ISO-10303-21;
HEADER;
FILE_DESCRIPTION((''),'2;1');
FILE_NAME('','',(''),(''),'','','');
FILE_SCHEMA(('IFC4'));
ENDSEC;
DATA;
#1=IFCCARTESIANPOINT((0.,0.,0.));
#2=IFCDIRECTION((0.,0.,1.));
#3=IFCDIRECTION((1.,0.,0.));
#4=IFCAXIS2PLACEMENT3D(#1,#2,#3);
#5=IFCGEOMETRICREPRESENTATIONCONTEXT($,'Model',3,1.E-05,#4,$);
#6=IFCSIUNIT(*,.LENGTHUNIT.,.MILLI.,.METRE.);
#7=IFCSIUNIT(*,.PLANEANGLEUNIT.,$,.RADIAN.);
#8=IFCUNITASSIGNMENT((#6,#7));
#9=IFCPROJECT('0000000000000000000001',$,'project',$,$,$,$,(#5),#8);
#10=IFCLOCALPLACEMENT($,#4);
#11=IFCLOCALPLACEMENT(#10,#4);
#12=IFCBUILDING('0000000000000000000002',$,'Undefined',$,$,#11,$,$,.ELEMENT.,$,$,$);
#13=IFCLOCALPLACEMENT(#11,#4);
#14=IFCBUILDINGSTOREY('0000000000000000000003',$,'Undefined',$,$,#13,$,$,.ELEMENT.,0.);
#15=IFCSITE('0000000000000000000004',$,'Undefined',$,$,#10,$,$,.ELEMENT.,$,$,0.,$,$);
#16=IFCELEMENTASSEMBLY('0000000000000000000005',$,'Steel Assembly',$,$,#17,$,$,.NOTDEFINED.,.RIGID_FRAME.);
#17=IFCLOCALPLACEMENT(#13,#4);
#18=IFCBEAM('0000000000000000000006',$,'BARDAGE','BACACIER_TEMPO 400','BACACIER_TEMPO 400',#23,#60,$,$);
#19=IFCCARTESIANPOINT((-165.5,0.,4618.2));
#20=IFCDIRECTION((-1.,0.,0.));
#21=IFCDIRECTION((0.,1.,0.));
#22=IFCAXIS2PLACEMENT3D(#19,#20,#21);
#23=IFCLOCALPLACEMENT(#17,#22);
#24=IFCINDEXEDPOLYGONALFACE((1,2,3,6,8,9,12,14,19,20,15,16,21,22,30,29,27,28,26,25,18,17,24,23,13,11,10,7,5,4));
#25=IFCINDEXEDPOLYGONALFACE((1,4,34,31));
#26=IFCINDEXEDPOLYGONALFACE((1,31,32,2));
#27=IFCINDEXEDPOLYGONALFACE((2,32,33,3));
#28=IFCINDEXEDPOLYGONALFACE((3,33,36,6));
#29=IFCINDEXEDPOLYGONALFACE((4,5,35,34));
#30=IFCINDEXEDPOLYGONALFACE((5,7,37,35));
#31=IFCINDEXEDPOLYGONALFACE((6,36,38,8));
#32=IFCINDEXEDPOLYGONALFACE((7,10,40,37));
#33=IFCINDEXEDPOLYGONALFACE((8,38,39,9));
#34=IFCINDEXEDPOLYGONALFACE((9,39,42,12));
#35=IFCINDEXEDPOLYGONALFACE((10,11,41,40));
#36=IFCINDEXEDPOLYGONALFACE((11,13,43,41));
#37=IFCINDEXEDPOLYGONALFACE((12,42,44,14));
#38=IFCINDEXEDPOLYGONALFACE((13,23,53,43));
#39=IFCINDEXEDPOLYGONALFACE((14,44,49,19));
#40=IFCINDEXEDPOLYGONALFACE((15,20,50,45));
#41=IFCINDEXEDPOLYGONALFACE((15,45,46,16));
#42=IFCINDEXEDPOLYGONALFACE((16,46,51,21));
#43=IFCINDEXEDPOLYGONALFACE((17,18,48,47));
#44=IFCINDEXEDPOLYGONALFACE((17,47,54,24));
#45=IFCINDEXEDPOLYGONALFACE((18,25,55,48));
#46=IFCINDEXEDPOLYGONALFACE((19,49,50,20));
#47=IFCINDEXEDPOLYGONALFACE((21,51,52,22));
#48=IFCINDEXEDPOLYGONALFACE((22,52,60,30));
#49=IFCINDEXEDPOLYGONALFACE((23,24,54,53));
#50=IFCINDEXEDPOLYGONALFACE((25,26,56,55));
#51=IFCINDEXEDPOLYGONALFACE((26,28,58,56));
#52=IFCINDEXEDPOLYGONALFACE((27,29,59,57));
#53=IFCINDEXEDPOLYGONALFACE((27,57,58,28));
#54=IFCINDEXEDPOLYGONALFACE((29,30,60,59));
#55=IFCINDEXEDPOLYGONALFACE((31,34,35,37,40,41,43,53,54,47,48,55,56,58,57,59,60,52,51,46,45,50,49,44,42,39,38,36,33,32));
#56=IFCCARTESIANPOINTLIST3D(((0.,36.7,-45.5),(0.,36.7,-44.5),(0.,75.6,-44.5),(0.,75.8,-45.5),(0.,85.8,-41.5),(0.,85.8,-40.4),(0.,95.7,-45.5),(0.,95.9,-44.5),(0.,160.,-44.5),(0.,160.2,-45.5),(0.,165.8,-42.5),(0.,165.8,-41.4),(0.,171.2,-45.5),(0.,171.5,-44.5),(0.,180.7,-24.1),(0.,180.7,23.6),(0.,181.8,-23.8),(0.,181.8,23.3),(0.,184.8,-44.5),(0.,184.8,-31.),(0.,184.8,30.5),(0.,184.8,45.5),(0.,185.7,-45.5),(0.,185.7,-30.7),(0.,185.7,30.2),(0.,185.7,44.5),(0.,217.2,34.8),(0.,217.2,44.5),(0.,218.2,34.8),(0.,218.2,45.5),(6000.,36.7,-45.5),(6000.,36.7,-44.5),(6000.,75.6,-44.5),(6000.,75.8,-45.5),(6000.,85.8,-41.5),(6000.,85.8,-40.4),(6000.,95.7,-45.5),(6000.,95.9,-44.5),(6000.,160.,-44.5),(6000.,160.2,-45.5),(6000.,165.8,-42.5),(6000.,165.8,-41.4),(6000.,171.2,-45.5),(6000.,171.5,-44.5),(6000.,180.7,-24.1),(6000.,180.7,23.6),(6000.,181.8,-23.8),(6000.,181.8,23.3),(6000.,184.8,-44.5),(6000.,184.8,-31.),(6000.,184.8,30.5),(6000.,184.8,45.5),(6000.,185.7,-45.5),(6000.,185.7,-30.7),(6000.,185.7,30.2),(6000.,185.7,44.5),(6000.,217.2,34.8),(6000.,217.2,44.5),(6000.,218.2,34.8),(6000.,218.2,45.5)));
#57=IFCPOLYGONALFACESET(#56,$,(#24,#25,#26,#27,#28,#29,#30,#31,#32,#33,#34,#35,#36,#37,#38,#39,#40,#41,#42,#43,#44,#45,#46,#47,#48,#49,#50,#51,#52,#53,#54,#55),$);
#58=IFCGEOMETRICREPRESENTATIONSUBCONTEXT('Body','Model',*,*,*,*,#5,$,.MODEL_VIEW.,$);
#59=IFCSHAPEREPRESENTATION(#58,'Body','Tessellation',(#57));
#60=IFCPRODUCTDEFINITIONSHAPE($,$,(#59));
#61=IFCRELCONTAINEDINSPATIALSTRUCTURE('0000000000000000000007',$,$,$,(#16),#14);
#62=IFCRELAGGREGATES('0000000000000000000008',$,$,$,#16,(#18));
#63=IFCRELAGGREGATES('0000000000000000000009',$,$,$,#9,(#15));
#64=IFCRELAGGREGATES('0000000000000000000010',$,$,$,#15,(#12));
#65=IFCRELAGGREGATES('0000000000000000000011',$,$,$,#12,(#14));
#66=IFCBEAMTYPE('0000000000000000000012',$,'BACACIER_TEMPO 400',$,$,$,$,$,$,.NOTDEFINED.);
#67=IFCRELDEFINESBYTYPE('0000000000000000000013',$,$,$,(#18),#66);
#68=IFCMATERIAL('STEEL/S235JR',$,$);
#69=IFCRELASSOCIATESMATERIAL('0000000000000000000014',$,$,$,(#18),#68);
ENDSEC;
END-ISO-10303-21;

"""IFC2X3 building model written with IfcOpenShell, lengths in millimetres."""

from ifc_helpers import new_model, si_unit, frame, origin_with_axes, place, context, subcontext, project, spatial, polyline, outline, extrude, clip, halfspace, material, type_object, element, aggregate, save


model = new_model("IFC2X3")

# Units and contexts
model_context = context("Model", 3, precision=1e-05, world=origin_with_axes())
body_context = subcontext(model_context, "Body", "Model", "MODEL_VIEW")
ifc_project = project(units=[si_unit("LENGTHUNIT", "METRE", prefix="MILLI"), si_unit("PLANEANGLEUNIT", "RADIAN")], contexts=[model_context])

# Site, building, storey
site_placement = place(None, origin_with_axes())
site = spatial("IfcSite", under=ifc_project, at=site_placement, Name="Undefined", CompositionType="ELEMENT", RefElevation=0.0)
building_placement = place(site_placement, origin_with_axes())
building = spatial("IfcBuilding", under=site, at=building_placement, Name="Undefined", CompositionType="ELEMENT")
storey_placement = place(building_placement, origin_with_axes())
storey = spatial("IfcBuildingStorey", under=building, at=storey_placement, Name="Undefined", CompositionType="ELEMENT", Elevation=0.0)

# Element assembly, beam
ifc_material_1 = material(Name="STEEL/S235JR")
assembly_1_placement = place(storey_placement, origin_with_axes())
assembly_1 = element("IfcElementAssembly", 1, at=assembly_1_placement, inside=storey, Name="Steel Assembly", AssemblyPlace="NOTDEFINED", PredefinedType="RIGID_FRAME")
beam_type_1 = type_object("IfcBeamType", Name="BACACIER_TEMPO 400", PredefinedType="NOTDEFINED")
beam_1_placement = place(assembly_1_placement, frame((-165.5, 0.0, 4618.2), z_axis=(-1.0, 0.0, 0.0), x_axis=(0.0, 1.0, 0.0)))
beam_1 = element("IfcBeam", 2, at=beam_1_placement, type_object=beam_type_1, material=ifc_material_1, Name="BARDAGE", Description="BACACIER_TEMPO 400", ObjectType="BACACIER_TEMPO 400", context=body_context, shape_type="Clipping", body=[
    clip(extrude(outline(polyline([(218.2, -25.0), (214.2, -31.9), (214.2, -45.5), (199.8, -45.5), (194.2, -42.5), (188.8, -45.5), (124.2, -45.5), (114.2, -41.5), (104.2, -45.5), (24.2, -45.5), (14.2, -41.5), (4.2, -45.5), (-75.8, -45.5), (-85.8, -41.5), (-95.8, -45.5), (-160.2, -45.5), (-165.8, -42.5), (-171.2, -45.5), (-185.8, -45.5), (-185.8, -30.7), (-181.8, -23.8), (-181.8, 23.3), (-185.8, 30.2), (-185.8, 44.5), (-217.2, 44.5), (-217.2, 34.8), (-218.2, 34.8), (-218.2, 45.5), (-184.8, 45.5), (-184.8, 30.5), (-180.8, 23.6), (-180.8, -24.1), (-184.8, -31.0), (-184.8, -44.5), (-171.5, -44.5), (-165.8, -41.4), (-160.0, -44.5), (-95.9, -44.5), (-85.8, -40.4), (-75.6, -44.5), (4.1, -44.5), (14.2, -40.4), (24.4, -44.5), (104.1, -44.5), (114.2, -40.4), (124.4, -44.5), (188.5, -44.5), (194.2, -41.4), (200.0, -44.5), (213.2, -44.5), (213.2, -31.6), (217.2, -24.7), (217.2, 21.7), (213.2, 28.6), (213.2, 42.0), (187.2, 42.0), (187.2, 32.5), (186.2, 32.5), (186.2, 43.0), (214.2, 43.0), (214.2, 28.9), (218.2, 22.0), (218.2, -25.0)])), frame((6000.0, 0.0, 0.0), z_axis=(-1.0, 0.0, 0.0), x_axis=(0.0, -1.0, 0.0)), (0.0, 0.0, 1.0), 6000.0), halfspace(frame((0.0, 36.7, -45.0), z_axis=(0.0, -1.0, 0.0), x_axis=(0.0, 0.0, 1.0)), False)),
])
aggregate(assembly_1, [beam_1])

save(model, "model.ifc")
